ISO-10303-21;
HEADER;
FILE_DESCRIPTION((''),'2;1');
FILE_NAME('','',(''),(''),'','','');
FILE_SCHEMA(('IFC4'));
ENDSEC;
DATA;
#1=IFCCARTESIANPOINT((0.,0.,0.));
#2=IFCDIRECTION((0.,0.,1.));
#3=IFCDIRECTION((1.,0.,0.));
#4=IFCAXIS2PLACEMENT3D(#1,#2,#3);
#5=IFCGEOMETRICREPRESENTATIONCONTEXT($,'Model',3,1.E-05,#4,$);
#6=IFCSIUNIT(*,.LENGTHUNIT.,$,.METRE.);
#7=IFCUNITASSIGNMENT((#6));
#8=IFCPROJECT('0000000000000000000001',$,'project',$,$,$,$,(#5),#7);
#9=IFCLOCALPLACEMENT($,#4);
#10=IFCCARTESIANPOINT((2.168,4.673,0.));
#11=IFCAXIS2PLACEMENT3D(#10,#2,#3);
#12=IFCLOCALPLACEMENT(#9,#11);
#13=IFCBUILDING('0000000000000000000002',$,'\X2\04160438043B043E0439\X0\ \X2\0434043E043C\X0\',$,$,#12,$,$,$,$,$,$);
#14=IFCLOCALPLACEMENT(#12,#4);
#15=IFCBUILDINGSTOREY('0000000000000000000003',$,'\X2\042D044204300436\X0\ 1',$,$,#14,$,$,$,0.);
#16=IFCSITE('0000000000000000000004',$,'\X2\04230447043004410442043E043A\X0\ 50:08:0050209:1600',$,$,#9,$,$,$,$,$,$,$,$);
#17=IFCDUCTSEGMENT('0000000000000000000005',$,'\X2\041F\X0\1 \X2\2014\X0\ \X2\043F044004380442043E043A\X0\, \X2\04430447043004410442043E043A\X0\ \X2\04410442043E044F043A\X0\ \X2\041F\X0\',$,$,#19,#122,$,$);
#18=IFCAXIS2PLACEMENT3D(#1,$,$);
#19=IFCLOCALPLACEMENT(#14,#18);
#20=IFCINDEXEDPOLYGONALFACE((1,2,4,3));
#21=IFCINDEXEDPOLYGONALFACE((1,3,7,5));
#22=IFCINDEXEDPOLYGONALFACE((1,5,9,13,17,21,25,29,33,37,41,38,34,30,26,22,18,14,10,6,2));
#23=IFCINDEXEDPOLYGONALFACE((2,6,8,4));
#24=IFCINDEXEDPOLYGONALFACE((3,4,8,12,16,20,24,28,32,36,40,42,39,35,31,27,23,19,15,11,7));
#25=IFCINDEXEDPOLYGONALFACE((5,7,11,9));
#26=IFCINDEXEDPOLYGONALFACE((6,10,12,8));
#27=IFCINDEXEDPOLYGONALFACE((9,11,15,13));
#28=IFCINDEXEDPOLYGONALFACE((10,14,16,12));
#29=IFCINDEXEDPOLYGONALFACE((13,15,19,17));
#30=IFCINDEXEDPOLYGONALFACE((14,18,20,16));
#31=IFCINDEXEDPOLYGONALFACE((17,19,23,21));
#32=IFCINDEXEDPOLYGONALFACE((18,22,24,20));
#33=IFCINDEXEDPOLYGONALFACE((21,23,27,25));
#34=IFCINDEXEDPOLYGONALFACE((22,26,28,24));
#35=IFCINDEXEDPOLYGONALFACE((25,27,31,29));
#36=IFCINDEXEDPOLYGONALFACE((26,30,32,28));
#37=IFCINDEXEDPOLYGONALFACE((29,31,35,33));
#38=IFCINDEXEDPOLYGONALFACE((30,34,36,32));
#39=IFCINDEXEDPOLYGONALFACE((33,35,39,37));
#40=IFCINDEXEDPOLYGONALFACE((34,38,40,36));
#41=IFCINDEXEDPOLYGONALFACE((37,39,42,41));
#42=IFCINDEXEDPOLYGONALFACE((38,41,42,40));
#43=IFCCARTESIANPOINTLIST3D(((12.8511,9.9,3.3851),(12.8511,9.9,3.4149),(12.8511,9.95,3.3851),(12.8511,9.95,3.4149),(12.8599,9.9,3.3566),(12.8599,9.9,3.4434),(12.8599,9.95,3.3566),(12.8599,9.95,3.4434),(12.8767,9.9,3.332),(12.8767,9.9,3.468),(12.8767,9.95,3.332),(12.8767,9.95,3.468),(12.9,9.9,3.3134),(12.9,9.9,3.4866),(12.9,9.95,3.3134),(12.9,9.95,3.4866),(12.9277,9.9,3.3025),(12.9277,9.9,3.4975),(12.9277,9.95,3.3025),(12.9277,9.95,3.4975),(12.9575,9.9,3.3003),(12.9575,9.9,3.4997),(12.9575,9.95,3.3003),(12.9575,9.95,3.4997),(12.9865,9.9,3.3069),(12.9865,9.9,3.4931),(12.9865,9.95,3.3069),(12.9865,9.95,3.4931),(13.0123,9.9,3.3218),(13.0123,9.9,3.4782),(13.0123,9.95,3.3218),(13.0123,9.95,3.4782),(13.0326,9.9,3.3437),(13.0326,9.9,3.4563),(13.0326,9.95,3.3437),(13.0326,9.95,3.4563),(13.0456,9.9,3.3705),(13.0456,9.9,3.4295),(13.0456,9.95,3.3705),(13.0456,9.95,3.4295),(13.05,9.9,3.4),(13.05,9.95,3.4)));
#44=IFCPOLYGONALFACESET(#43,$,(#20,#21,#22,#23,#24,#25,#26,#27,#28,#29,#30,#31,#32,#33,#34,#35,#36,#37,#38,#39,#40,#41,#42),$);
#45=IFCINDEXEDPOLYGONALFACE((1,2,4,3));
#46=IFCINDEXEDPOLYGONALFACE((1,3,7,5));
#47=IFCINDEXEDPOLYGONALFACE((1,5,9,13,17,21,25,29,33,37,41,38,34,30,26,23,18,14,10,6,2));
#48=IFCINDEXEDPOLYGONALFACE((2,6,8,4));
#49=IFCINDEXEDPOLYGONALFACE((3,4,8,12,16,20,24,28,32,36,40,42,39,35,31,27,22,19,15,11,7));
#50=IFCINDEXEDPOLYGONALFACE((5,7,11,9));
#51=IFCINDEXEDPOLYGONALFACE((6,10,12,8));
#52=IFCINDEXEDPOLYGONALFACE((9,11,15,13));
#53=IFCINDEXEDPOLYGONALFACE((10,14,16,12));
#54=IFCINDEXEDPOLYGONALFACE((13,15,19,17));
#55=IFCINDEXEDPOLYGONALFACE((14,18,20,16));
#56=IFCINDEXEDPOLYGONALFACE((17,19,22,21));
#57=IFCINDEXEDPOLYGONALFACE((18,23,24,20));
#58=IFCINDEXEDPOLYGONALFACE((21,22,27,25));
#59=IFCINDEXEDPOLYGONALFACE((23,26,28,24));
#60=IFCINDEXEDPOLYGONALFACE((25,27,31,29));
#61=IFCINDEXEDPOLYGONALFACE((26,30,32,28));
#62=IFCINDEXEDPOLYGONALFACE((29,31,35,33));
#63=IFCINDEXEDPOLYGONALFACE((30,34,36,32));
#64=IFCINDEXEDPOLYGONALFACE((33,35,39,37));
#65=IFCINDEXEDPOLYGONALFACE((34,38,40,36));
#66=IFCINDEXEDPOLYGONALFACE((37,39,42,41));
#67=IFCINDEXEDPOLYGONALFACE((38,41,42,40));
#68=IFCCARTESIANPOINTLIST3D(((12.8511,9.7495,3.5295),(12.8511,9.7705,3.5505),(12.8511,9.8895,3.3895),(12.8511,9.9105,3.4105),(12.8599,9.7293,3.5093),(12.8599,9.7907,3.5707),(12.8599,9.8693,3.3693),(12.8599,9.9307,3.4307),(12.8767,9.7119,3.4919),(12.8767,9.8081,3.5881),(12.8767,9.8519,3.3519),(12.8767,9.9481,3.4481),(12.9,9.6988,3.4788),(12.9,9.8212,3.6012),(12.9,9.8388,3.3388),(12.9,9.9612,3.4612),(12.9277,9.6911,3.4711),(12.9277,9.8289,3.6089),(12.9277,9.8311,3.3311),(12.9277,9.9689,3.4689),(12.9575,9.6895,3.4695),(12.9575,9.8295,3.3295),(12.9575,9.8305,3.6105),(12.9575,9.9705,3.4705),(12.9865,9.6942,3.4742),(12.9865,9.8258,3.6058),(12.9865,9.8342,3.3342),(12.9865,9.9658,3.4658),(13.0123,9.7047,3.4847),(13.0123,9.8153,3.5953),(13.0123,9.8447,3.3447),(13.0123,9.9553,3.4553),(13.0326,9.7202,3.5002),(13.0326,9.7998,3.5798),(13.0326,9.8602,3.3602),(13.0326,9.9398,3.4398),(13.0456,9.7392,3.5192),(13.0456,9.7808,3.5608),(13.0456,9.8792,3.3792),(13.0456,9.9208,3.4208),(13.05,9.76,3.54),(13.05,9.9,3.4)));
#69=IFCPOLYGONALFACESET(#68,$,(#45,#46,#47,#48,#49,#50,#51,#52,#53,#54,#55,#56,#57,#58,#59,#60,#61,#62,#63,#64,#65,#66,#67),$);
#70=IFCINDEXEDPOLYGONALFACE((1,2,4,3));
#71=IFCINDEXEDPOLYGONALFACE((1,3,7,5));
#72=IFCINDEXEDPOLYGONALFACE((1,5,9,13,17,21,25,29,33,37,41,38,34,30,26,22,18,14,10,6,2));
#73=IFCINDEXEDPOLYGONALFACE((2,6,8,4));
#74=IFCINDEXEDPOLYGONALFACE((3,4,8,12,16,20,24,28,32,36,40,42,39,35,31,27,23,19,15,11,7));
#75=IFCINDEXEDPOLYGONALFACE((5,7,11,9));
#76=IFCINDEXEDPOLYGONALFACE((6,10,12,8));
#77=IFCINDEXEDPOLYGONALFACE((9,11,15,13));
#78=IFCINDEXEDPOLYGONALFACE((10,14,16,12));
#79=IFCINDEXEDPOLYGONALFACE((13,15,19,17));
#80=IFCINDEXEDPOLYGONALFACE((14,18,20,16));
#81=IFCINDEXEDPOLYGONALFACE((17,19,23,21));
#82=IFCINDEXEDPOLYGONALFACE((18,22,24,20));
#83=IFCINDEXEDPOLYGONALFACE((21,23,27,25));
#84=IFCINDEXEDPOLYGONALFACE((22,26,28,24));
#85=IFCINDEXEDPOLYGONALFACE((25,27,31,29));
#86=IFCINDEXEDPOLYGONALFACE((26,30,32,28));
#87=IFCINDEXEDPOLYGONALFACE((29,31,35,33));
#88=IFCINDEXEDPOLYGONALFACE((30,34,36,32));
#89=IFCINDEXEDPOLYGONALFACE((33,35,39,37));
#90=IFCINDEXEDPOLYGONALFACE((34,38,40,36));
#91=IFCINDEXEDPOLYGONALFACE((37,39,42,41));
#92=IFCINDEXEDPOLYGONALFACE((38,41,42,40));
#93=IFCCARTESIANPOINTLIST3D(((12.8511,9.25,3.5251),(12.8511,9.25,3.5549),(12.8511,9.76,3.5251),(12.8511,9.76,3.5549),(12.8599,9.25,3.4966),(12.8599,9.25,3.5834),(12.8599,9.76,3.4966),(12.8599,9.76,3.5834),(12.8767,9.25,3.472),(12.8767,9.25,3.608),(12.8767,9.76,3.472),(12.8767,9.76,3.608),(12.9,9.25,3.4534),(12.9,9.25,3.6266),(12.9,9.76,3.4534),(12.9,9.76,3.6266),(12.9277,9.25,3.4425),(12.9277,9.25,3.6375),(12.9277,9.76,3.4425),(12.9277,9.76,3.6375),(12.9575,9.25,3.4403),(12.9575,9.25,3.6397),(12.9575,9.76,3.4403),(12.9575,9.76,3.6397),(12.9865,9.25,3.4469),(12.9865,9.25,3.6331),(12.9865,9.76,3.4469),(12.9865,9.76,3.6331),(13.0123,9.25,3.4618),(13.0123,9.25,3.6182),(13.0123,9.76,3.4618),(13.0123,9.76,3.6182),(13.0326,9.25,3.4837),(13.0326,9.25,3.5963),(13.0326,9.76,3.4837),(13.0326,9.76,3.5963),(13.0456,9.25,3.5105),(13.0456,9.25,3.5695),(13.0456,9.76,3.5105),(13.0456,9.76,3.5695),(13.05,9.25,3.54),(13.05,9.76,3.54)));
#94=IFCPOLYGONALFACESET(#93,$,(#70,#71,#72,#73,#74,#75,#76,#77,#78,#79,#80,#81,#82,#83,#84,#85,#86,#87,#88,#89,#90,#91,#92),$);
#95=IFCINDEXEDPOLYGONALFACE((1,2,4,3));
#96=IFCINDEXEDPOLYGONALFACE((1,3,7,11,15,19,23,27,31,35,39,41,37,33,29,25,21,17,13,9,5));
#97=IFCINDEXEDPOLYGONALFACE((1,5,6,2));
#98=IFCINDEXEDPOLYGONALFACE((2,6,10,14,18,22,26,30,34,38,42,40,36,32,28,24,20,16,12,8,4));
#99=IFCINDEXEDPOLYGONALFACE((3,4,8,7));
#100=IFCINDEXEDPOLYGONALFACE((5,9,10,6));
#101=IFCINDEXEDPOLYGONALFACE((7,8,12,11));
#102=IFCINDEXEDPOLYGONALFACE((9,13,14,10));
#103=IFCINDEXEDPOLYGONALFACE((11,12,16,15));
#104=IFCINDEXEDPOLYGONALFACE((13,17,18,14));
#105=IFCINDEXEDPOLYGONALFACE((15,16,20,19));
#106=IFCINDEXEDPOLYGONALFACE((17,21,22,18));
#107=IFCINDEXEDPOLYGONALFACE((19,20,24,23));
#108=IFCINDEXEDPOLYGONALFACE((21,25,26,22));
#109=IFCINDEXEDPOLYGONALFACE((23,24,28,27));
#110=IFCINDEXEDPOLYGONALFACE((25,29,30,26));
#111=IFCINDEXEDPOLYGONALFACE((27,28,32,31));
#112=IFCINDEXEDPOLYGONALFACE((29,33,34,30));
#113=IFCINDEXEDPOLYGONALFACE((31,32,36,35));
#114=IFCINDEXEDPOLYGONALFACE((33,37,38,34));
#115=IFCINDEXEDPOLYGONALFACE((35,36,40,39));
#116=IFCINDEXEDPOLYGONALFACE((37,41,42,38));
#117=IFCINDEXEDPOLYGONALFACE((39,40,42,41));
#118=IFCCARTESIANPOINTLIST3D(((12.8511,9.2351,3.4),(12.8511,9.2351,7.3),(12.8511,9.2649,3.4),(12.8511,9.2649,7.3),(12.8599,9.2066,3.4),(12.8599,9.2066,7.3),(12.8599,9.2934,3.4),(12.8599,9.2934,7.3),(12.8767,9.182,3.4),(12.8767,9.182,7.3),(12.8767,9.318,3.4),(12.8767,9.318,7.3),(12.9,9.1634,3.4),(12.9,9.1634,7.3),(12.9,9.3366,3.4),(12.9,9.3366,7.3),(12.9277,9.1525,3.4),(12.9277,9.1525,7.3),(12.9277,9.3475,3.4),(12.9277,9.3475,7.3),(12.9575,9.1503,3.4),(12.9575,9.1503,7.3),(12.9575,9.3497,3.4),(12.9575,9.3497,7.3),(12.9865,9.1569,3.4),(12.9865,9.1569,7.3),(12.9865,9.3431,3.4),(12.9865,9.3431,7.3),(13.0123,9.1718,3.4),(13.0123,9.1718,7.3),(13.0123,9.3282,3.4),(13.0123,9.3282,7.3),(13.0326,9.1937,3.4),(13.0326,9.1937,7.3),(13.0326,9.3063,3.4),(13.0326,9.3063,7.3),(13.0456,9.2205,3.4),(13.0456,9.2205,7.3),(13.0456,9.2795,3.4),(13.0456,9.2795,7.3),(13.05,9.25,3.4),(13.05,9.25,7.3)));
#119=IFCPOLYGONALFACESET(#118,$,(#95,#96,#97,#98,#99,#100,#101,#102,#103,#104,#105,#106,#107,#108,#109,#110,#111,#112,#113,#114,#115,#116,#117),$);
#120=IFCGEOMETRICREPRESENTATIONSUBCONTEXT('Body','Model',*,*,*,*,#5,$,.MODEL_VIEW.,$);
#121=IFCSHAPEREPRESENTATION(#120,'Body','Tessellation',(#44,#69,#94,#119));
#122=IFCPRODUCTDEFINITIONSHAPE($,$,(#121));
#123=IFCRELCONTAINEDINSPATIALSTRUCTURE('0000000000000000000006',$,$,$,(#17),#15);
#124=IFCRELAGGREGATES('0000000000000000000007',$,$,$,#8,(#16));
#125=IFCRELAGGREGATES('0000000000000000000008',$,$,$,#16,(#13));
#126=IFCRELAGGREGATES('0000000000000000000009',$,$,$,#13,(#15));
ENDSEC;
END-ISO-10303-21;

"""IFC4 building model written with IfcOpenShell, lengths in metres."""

from ifc_helpers import new_model, si_unit, frame, origin_with_axes, origin_2d, place, context, subcontext, project, spatial, circle, extrude, element, save


model = new_model("IFC4")

# Units and contexts
model_context = context("Model", 3, precision=1e-05, world=origin_with_axes())
body_context = subcontext(model_context, "Body", "Model", "MODEL_VIEW")
ifc_project = project(units=[si_unit("LENGTHUNIT", "METRE")], contexts=[model_context])

# Site, building, storey
site_placement = place(None, origin_with_axes())
site = spatial("IfcSite", under=ifc_project, at=site_placement, Name="Участок 50:08:0050209:1600")
building_placement = place(site_placement, frame((2.168, 4.673, 0.0), z_axis=(0.0, 0.0, 1.0), x_axis=(1.0, 0.0, 0.0)))
building = spatial("IfcBuilding", under=site, at=building_placement, Name="Жилой дом")
storey_placement = place(building_placement, origin_with_axes())
storey = spatial("IfcBuildingStorey", under=building, at=storey_placement, Name="Этаж 1", Elevation=0.0)

# Duct segment
duct_segment_1_placement = place(storey_placement, origin_with_axes())
element("IfcDuctSegment", 1, at=duct_segment_1_placement, inside=storey, Name="П1 — приток, участок стояк П", context=body_context, shape_type="SweptSolid", body=[
    extrude(circle(Radius=0.1, at=origin_2d()), frame((12.95, 9.95, 3.4), z_axis=(0.0, -1.0, 0.0), x_axis=(1.0, 0.0, 0.0)), (0.0, 0.0, 1.0), 0.05),
    extrude(circle(Radius=0.1, at=origin_2d()), frame((12.95, 9.9, 3.4), z_axis=(0.0, -0.707107, 0.707107), x_axis=(1.0, 0.0, 0.0)), (0.0, 0.0, 1.0), 0.198),
    extrude(circle(Radius=0.1, at=origin_2d()), frame((12.95, 9.76, 3.54), z_axis=(0.0, -1.0, 0.0), x_axis=(1.0, 0.0, 0.0)), (0.0, 0.0, 1.0), 0.51),
    extrude(circle(Radius=0.1, at=origin_2d()), frame((12.95, 9.25, 3.4), z_axis=(0.0, 0.0, 1.0), x_axis=(1.0, 0.0, 0.0)), (0.0, 0.0, 1.0), 3.9),
])

save(model, "model.ifc")
